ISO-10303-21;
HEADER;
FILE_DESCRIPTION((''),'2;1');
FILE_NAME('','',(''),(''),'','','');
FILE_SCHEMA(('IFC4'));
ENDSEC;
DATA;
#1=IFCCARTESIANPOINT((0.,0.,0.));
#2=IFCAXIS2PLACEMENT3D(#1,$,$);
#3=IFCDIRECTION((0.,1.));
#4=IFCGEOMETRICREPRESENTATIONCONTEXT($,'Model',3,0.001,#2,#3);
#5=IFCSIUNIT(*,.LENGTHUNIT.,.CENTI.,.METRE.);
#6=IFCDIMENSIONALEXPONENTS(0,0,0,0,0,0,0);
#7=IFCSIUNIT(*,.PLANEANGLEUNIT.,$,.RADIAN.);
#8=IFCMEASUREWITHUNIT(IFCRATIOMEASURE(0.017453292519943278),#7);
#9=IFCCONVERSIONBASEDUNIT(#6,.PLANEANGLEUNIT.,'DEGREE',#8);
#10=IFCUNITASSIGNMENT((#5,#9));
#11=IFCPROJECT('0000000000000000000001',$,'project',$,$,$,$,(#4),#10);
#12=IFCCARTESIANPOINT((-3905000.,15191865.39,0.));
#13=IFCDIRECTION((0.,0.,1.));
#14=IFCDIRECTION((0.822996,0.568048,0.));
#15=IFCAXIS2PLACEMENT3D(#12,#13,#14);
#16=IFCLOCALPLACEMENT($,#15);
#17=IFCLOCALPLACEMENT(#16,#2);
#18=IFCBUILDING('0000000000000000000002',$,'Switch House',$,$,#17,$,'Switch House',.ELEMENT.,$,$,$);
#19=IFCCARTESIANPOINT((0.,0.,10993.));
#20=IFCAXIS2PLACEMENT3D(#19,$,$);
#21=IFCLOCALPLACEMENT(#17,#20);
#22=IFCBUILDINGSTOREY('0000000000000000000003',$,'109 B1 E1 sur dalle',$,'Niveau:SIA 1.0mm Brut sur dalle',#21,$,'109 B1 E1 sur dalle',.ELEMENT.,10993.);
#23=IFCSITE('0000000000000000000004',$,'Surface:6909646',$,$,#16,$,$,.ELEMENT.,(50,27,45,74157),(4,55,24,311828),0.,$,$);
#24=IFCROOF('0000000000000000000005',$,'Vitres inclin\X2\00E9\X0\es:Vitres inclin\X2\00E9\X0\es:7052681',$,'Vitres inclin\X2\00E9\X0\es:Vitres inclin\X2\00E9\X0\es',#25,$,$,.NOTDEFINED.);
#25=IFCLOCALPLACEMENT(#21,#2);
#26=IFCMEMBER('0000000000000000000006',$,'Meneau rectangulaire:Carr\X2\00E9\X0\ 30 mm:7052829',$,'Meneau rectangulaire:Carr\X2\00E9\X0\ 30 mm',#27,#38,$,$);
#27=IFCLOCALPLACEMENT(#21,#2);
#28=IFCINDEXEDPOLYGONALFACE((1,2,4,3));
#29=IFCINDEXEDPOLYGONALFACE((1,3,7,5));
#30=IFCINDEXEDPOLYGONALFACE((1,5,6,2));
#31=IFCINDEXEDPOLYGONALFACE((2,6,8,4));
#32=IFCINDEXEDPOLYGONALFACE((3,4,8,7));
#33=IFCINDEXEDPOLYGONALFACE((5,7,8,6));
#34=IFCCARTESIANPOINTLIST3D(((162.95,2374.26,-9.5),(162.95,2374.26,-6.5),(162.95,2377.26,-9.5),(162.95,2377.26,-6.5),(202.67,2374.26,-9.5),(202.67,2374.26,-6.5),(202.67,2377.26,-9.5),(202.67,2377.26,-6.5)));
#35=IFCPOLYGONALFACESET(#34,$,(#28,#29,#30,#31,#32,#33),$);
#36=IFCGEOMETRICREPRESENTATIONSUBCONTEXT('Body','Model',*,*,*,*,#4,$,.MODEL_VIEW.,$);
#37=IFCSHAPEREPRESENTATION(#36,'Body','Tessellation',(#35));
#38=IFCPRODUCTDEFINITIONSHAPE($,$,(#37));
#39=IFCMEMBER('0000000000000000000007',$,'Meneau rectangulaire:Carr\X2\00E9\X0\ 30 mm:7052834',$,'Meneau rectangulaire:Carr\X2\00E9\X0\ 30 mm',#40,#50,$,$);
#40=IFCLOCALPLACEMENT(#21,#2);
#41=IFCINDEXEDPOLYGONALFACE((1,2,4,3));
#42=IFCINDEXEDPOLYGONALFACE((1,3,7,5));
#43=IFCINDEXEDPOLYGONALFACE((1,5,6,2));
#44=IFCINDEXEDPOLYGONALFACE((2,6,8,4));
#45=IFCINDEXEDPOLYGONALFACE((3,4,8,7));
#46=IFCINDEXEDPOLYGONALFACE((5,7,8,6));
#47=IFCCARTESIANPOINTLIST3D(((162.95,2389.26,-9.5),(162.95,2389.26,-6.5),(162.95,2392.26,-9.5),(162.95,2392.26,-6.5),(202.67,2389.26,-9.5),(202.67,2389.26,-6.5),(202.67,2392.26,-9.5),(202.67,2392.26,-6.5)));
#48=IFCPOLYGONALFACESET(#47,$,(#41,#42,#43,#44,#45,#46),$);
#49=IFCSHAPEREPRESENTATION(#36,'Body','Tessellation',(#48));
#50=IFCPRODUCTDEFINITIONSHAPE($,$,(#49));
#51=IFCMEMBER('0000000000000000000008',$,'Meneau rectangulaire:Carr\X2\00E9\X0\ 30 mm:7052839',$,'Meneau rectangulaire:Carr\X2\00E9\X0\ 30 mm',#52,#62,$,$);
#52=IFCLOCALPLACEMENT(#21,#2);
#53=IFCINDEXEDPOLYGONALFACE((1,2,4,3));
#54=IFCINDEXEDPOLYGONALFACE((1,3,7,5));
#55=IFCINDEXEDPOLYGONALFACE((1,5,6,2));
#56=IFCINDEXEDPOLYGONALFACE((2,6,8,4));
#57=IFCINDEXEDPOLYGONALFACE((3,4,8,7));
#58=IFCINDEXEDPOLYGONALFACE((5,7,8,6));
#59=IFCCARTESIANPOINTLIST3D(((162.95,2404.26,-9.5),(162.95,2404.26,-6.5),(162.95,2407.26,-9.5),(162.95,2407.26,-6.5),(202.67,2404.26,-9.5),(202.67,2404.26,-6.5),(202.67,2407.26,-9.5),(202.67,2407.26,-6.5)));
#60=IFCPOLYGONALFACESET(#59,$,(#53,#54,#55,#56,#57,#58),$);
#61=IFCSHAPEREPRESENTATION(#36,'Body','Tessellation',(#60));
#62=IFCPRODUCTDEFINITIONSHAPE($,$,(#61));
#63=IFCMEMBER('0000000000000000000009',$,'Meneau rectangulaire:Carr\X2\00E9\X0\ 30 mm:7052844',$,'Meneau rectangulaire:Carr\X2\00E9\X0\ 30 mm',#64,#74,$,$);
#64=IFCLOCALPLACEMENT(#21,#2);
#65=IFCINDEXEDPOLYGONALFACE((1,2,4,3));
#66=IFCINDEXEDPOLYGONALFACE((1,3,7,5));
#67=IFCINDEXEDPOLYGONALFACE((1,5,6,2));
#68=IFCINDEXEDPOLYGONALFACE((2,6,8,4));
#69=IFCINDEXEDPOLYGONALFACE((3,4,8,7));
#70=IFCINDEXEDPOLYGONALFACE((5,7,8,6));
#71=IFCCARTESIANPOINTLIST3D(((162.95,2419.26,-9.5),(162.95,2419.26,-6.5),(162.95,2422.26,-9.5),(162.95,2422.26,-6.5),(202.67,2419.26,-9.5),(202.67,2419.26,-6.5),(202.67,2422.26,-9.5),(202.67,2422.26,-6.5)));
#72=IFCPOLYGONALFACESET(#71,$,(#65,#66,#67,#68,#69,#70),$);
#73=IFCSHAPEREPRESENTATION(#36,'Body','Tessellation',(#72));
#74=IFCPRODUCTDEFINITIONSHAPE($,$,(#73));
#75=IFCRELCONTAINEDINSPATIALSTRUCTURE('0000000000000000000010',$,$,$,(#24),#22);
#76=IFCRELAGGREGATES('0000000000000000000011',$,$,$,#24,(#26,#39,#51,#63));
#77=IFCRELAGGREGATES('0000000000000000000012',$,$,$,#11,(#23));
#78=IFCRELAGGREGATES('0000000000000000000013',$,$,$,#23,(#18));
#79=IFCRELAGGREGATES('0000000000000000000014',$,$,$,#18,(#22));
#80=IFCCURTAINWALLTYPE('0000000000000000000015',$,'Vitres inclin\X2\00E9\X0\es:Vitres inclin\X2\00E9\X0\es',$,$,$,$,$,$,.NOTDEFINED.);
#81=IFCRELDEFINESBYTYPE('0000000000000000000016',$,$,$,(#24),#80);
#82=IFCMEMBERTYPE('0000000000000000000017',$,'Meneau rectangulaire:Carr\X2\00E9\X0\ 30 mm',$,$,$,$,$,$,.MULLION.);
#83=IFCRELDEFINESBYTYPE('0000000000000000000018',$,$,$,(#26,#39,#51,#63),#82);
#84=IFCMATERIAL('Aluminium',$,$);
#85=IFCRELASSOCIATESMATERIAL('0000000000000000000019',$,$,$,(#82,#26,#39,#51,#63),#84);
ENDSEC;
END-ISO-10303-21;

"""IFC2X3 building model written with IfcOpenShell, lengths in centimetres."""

from ifc_helpers import new_model, entity, si_unit, converted_unit, direction, frame, origin, origin_2d_with_axis, place, context, subcontext, project, spatial, rectangle, extrude, source, transform, mapped, material, type_object, type_shapes, element, aggregate, save


model = new_model("IFC2X3")

# Units and contexts
model_context = context("Model", 3, precision=0.001, world=origin(), true_north=direction((0.0, 1.0)))
body_context = subcontext(model_context, "Body", "Model", "MODEL_VIEW")
ifc_project = project(units=[si_unit("LENGTHUNIT", "METRE", prefix="CENTI"), converted_unit("PLANEANGLEUNIT", "DEGREE", entity("IfcRatioMeasure", 0.017453292519943278), si_unit("PLANEANGLEUNIT", "RADIAN"), dimensions=[0, 0, 0, 0, 0, 0, 0])], contexts=[model_context])

# Site, building, storey
site_placement = place(None, frame((-3905000.0, 15191865.39, 0.0), z_axis=(0.0, 0.0, 1.0), x_axis=(0.822996, 0.568048, 0.0)))
site = spatial("IfcSite", under=ifc_project, at=site_placement, Name="Surface:6909646", CompositionType="ELEMENT", RefLatitude=(50, 27, 45, 74157), RefLongitude=(4, 55, 24, 311828), RefElevation=0.0)
building_placement = place(site_placement, origin())
building = spatial("IfcBuilding", under=site, at=building_placement, Name="Switch House", LongName="Switch House", CompositionType="ELEMENT")
storey_placement = place(building_placement, frame((0.0, 0.0, 10993.0)))
storey = spatial("IfcBuildingStorey", under=building, at=storey_placement, Name="109 B1 E1 sur dalle", ObjectType="Niveau:SIA 1.0mm Brut sur dalle", LongName="109 B1 E1 sur dalle", CompositionType="ELEMENT", Elevation=10993.0)

# Roof, members
curtain_wall_type = type_object("IfcCurtainWallType", Name="Vitres inclinées:Vitres inclinées", PredefinedType="NOTDEFINED")
roof_placement = place(storey_placement, frame((0.0, 0.0, -10993.0)))
roof = element("IfcRoof", 1, at=roof_placement, inside=storey, type_object=curtain_wall_type, Name="Vitres inclinées:Vitres inclinées:7052681", ObjectType="Vitres inclinées:Vitres inclinées", ShapeType="NOTDEFINED")
ifc_material = material(Name="Aluminium")
member_type_1 = type_object("IfcMemberType", Name="Meneau rectangulaire:Carré 30 mm", PredefinedType="MULLION", material=ifc_material)
shared_shape_1 = source(origin(), body_context, "Body", "SweptSolid", [
    extrude(rectangle(XDim=3.0, YDim=3.0, at=origin_2d_with_axis()), frame((0.0, 0.0, -39.72), z_axis=(0.0, 0.0, 1.0), x_axis=(0.0, -1.0, 0.0)), (0.0, 0.0, 1.0), 39.72),
])
type_shapes(member_type_1, [shared_shape_1])
member_1_placement = place(roof_placement, frame((162.95, 2375.76, 10985.0), z_axis=(-1.0, 0.0, 0.0), x_axis=(0.0, 1.0, 0.0)))
member_1 = element("IfcMember", 2, at=member_1_placement, type_object=member_type_1, material=ifc_material, Name="Meneau rectangulaire:Carré 30 mm:7052829", ObjectType="Meneau rectangulaire:Carré 30 mm", context=body_context, shape_type="MappedRepresentation", body=[
    mapped(shared_shape_1, transform((0.0, 0.0, 0.0), scale=1.0)),
])
member_2_placement = place(roof_placement, frame((162.95, 2390.76, 10985.0), z_axis=(-1.0, 0.0, 0.0), x_axis=(0.0, 1.0, 0.0)))
member_2 = element("IfcMember", 3, at=member_2_placement, type_object=member_type_1, material=ifc_material, Name="Meneau rectangulaire:Carré 30 mm:7052834", ObjectType="Meneau rectangulaire:Carré 30 mm", context=body_context, shape_type="MappedRepresentation", body=[
    mapped(shared_shape_1, transform((0.0, 0.0, 0.0), scale=1.0)),
])
member_3_placement = place(roof_placement, frame((162.95, 2405.76, 10985.0), z_axis=(-1.0, 0.0, 0.0), x_axis=(0.0, 1.0, 0.0)))
member_3 = element("IfcMember", 4, at=member_3_placement, type_object=member_type_1, material=ifc_material, Name="Meneau rectangulaire:Carré 30 mm:7052839", ObjectType="Meneau rectangulaire:Carré 30 mm", context=body_context, shape_type="MappedRepresentation", body=[
    mapped(shared_shape_1, transform((0.0, 0.0, 0.0), scale=1.0)),
])
member_4_placement = place(roof_placement, frame((162.95, 2420.76, 10985.0), z_axis=(-1.0, 0.0, 0.0), x_axis=(0.0, 1.0, 0.0)))
member_4 = element("IfcMember", 5, at=member_4_placement, type_object=member_type_1, material=ifc_material, Name="Meneau rectangulaire:Carré 30 mm:7052844", ObjectType="Meneau rectangulaire:Carré 30 mm", context=body_context, shape_type="MappedRepresentation", body=[
    mapped(shared_shape_1, transform((0.0, 0.0, 0.0), scale=1.0)),
])
aggregate(roof, [member_1, member_2, member_3, member_4])

save(model, "model.ifc")
